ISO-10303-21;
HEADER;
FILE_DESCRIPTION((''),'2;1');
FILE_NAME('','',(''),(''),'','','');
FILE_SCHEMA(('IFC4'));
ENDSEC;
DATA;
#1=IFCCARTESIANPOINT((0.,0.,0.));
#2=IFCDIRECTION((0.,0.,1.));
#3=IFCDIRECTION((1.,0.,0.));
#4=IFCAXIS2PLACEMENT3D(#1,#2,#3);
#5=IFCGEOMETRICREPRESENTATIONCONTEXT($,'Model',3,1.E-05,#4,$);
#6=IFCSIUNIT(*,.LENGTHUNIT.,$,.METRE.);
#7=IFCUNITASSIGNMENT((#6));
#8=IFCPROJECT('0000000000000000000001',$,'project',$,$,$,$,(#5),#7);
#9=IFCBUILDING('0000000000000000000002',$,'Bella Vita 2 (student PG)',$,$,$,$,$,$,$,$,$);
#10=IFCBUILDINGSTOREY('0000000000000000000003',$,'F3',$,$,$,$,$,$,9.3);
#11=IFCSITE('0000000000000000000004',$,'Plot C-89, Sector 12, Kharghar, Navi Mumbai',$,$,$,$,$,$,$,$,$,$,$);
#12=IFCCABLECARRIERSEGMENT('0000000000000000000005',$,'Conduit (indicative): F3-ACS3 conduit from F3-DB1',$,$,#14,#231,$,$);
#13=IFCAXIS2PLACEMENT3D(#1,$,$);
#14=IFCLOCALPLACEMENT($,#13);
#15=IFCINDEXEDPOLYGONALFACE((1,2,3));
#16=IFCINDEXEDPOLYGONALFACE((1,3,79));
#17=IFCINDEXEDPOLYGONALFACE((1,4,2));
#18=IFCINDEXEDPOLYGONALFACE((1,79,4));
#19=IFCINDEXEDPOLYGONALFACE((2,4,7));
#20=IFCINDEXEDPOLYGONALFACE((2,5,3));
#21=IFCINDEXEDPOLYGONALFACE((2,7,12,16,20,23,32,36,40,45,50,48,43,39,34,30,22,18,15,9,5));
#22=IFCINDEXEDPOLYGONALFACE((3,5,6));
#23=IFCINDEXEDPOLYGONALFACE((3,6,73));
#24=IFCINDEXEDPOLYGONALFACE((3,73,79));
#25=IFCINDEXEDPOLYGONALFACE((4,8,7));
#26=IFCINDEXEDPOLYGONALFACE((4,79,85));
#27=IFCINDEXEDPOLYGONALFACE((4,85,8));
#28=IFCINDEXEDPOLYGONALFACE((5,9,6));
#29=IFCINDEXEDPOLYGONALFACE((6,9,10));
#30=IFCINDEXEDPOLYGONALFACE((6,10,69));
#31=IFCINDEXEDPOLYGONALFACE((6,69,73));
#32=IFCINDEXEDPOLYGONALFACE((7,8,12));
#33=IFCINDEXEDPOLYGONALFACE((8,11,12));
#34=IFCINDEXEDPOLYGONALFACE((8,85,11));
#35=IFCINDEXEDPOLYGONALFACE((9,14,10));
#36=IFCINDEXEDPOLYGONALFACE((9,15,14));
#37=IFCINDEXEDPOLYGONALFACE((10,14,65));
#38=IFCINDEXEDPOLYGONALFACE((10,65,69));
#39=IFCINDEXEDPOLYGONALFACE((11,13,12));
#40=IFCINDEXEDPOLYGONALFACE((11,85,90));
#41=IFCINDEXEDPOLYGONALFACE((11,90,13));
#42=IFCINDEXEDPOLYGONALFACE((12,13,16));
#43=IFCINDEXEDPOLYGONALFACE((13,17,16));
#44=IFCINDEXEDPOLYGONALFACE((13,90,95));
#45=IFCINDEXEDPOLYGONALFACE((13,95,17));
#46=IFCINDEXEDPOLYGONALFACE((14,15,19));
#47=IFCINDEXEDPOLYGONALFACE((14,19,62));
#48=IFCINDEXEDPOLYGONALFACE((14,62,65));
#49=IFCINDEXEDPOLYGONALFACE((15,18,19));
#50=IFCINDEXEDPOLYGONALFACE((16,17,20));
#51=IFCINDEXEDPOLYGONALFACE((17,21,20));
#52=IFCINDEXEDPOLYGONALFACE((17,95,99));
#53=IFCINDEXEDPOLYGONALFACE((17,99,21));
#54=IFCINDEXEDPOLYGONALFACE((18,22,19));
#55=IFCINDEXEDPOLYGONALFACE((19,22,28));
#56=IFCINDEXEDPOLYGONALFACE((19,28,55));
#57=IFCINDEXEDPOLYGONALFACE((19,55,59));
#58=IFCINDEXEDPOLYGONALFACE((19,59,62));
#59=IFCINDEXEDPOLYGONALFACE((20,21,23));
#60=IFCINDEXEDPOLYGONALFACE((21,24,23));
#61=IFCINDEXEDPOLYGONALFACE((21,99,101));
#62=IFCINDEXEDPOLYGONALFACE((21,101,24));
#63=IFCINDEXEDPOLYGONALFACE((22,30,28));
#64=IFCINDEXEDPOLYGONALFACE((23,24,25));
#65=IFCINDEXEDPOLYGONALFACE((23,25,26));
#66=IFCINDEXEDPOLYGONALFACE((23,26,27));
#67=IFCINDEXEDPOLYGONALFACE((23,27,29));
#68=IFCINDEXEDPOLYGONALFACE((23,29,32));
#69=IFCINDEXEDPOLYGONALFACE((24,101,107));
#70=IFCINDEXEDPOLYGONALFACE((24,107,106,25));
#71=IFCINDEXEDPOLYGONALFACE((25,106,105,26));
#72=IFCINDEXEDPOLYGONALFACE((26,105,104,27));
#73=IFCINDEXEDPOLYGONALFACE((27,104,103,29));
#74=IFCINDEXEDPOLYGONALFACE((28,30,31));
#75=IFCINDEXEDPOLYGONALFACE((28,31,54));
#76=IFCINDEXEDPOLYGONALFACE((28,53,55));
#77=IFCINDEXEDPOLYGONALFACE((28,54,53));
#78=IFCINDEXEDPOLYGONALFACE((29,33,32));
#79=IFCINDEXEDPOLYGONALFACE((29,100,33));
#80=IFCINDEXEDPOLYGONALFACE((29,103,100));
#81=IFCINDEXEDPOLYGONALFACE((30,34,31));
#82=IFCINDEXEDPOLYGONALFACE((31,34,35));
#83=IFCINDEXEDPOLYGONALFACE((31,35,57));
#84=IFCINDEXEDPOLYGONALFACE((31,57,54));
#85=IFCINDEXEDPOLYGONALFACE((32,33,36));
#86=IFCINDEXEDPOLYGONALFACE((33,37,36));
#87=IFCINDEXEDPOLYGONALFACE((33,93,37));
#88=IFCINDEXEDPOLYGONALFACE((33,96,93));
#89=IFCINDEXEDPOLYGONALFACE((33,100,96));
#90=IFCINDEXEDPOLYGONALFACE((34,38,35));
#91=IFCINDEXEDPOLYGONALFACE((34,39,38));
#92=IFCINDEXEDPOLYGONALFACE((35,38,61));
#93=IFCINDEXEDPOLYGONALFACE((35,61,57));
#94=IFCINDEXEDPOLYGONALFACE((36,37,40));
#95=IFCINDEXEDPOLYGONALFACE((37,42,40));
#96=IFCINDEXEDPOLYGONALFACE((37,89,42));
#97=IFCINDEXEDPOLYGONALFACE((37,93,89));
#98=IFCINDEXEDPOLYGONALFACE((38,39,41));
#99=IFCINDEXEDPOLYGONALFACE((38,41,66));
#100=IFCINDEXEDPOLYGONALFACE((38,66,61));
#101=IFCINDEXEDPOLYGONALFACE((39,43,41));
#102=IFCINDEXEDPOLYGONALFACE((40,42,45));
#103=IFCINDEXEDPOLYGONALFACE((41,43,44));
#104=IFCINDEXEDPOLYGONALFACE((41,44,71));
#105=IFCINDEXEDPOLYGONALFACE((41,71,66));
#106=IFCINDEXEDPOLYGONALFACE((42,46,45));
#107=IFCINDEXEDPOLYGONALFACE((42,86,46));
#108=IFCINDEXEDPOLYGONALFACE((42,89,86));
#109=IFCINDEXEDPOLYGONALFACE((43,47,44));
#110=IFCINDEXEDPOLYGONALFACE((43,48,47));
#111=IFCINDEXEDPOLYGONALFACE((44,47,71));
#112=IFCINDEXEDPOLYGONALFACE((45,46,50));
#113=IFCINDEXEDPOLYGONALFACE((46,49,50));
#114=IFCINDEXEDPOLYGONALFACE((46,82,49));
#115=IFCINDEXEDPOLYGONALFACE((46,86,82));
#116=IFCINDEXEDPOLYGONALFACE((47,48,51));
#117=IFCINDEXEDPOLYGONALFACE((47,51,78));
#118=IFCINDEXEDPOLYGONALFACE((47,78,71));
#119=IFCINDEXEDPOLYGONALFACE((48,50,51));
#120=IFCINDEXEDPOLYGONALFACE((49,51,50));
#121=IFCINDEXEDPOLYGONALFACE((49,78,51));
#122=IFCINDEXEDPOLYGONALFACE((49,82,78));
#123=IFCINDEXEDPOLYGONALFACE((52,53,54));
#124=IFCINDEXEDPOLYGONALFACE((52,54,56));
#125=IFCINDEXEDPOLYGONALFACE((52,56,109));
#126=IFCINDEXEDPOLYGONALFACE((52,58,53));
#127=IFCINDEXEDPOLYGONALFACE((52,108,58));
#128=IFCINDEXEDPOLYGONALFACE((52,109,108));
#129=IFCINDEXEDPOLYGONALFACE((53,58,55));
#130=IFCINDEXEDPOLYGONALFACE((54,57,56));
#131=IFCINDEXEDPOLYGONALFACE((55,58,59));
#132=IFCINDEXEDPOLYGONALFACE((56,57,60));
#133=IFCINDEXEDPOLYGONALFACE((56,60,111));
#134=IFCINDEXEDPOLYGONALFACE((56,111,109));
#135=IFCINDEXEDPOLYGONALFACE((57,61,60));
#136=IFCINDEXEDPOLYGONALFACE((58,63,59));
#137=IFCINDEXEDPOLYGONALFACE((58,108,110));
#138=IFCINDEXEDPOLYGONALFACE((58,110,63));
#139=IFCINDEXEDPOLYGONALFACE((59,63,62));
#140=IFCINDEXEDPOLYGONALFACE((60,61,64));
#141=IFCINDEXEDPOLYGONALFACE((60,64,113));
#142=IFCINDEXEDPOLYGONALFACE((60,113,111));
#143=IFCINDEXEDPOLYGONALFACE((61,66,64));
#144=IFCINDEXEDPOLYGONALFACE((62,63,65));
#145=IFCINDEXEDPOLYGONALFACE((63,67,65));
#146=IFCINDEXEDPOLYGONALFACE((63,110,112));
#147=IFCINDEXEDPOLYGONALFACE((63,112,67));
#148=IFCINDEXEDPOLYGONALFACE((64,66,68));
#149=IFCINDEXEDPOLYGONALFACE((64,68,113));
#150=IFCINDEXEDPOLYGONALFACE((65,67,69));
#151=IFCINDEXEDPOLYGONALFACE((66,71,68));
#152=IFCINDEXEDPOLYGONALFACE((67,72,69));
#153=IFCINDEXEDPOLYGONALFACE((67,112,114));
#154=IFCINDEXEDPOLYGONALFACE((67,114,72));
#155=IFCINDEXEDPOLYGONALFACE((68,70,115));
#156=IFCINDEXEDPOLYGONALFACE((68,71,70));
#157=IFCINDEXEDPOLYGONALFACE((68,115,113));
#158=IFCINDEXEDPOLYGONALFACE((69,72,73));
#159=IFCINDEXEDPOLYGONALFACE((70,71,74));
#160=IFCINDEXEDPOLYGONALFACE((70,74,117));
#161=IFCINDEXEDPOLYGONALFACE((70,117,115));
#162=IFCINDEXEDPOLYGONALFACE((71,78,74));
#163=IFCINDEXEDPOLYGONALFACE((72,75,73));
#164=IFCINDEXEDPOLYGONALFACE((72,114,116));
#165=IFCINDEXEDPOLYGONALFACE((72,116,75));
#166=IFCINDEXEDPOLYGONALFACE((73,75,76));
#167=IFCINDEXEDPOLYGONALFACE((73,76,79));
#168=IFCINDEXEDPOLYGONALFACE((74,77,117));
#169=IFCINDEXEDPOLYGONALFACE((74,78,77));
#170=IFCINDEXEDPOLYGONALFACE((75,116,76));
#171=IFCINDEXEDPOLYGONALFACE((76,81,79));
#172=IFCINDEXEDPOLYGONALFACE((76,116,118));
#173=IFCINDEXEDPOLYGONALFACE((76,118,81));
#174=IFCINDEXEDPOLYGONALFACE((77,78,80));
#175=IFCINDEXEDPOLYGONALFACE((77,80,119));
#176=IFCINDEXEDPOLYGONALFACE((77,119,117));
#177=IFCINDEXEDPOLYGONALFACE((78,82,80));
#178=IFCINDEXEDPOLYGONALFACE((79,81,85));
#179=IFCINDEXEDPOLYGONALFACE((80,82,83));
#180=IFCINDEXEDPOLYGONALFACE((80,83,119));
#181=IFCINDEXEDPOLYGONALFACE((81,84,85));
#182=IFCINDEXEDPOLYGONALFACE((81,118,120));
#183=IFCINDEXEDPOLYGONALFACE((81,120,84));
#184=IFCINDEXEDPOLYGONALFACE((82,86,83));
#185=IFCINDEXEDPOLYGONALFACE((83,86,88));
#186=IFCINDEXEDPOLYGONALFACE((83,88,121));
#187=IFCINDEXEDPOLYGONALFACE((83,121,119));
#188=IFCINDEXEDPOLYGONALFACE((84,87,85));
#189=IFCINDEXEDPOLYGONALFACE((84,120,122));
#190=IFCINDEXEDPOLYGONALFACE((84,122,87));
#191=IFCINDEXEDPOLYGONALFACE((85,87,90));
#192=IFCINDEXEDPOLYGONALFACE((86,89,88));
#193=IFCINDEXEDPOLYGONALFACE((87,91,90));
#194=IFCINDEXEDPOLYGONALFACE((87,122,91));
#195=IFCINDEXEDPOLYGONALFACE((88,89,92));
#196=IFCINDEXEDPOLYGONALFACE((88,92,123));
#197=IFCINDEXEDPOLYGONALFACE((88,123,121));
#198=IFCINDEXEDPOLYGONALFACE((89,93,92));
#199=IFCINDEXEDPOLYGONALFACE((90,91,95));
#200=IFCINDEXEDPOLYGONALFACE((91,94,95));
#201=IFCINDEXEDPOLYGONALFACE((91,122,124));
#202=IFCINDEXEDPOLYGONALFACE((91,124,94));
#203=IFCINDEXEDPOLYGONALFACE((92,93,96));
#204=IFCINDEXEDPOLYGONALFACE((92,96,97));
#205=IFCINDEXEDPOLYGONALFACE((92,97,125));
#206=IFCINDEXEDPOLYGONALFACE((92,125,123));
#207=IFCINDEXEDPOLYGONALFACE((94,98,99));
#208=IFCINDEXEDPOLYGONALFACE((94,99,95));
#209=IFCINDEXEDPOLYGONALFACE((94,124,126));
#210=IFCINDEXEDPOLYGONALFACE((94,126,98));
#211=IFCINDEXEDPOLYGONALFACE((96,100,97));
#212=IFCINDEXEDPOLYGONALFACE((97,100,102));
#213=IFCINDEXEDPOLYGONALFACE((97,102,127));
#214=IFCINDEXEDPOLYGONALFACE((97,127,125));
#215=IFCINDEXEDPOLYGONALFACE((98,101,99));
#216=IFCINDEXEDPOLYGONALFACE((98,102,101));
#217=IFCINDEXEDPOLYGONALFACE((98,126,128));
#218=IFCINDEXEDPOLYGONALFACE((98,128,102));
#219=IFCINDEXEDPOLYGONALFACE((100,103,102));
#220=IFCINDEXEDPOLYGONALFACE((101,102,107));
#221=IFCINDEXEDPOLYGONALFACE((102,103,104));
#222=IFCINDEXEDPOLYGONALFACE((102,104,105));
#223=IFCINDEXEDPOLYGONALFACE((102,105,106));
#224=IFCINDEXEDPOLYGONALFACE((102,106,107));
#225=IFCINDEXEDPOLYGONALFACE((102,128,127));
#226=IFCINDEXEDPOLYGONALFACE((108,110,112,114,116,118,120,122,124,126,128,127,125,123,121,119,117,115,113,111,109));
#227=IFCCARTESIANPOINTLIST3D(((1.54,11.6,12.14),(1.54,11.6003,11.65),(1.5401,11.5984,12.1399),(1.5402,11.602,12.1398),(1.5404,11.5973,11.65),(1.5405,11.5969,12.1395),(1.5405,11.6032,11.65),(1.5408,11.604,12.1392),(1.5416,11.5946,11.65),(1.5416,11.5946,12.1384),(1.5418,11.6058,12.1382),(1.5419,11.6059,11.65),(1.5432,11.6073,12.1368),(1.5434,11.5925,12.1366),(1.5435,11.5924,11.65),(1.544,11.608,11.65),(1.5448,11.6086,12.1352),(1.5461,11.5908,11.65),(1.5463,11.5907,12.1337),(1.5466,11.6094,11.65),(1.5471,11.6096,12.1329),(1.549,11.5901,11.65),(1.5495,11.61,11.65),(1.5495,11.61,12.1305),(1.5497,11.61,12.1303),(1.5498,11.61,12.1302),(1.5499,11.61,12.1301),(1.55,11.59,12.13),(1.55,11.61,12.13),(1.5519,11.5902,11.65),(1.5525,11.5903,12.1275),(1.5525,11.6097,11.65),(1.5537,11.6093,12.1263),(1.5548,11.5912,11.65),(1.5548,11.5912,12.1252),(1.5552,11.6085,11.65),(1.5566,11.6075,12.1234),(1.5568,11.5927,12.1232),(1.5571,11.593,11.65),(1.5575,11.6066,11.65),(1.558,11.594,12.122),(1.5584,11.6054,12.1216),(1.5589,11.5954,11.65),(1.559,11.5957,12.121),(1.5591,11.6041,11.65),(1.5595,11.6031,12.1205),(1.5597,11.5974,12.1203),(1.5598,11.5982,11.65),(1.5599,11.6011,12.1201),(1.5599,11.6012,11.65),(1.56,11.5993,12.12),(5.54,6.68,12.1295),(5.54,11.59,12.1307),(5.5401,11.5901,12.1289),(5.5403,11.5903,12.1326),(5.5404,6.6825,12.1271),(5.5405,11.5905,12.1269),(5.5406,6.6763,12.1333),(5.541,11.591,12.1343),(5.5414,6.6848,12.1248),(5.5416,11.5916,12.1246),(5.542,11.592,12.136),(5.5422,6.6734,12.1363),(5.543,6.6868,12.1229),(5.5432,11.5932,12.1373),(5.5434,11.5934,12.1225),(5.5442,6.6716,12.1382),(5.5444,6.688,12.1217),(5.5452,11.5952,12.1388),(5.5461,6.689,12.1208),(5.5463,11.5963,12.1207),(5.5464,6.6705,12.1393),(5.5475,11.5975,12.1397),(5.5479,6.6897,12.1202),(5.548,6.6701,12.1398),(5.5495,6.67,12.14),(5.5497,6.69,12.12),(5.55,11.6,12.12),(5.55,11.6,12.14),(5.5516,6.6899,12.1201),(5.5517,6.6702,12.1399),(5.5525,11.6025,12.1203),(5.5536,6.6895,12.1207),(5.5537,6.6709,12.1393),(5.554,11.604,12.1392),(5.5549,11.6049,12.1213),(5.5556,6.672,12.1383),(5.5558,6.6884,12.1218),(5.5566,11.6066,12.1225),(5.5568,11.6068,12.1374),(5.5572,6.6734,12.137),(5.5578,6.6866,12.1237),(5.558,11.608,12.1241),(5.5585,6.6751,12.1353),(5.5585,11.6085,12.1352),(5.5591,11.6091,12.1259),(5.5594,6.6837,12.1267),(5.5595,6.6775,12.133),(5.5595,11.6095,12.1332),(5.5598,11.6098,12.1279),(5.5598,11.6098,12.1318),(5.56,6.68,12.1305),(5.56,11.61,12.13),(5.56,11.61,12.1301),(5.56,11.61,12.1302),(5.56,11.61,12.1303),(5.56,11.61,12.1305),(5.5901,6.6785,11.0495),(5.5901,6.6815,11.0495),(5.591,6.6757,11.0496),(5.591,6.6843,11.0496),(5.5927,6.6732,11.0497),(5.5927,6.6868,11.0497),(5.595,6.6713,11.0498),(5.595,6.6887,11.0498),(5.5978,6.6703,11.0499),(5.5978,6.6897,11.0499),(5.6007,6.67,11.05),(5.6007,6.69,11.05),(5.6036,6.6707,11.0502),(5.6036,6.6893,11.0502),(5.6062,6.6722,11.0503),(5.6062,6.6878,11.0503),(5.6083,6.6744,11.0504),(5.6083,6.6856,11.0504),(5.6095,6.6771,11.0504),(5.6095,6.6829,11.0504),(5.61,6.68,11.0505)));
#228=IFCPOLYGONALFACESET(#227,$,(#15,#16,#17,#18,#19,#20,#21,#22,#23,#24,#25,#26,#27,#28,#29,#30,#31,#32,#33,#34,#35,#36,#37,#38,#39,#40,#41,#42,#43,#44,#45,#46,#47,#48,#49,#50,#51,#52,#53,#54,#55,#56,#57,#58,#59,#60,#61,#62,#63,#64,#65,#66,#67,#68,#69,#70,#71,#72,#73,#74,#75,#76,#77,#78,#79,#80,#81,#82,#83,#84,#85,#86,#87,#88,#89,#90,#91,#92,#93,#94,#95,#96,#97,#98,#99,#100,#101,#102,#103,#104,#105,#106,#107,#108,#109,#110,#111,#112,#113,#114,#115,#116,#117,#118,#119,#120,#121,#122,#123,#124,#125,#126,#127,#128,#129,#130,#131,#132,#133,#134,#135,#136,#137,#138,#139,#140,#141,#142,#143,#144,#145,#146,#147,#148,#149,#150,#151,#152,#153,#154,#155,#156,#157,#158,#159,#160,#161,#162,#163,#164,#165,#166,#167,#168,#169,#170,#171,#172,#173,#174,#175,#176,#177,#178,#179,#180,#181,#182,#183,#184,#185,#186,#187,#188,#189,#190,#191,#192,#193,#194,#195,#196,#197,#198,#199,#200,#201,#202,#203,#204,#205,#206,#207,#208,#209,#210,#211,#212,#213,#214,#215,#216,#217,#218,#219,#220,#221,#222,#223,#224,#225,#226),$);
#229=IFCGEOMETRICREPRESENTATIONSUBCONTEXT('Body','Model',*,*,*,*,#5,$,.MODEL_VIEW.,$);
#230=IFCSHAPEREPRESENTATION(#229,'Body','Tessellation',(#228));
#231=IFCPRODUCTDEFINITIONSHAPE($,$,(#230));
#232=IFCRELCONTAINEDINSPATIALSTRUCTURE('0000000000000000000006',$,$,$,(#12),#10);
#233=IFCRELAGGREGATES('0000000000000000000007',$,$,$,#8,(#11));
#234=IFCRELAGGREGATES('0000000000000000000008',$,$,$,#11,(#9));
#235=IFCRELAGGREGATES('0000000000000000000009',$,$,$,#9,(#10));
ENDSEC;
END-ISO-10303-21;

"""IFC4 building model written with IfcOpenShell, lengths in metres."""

from ifc_helpers import new_model, entity, si_unit, origin, origin_with_axes, place, context, subcontext, project, spatial, element, save


model = new_model("IFC4")

# Units and contexts
model_context = context("Model", 3, precision=1e-05, world=origin_with_axes())
body_context = subcontext(model_context, "Body", "Model", "MODEL_VIEW")
ifc_project = project(units=[si_unit("LENGTHUNIT", "METRE")], contexts=[model_context])

# Site, building, storey
site = spatial("IfcSite", under=ifc_project, Name="Plot C-89, Sector 12, Kharghar, Navi Mumbai")
building = spatial("IfcBuilding", under=site, Name="Bella Vita 2 (student PG)")
storey = spatial("IfcBuildingStorey", under=building, Name="F3", Elevation=9.3)

# Cable carrier segment
cable_carrier_segment_1_placement = place(None, origin())
element("IfcCableCarrierSegment", 1, at=cable_carrier_segment_1_placement, inside=storey, Name="Conduit (indicative): F3-ACS3 conduit from F3-DB1", context=body_context, shape_type="AdvancedSweptSolid", body=[
    entity("IfcSweptDiskSolid", entity("IfcPolyline", [entity("IfcCartesianPoint", [5.6, 6.68, 11.05]), entity("IfcCartesianPoint", [5.55, 6.68, 12.13]), entity("IfcCartesianPoint", [5.55, 11.6, 12.13]), entity("IfcCartesianPoint", [1.55, 11.6, 12.13]), entity("IfcCartesianPoint", [1.55, 11.6, 11.65])]), 0.01),
])

save(model, "model.ifc")
